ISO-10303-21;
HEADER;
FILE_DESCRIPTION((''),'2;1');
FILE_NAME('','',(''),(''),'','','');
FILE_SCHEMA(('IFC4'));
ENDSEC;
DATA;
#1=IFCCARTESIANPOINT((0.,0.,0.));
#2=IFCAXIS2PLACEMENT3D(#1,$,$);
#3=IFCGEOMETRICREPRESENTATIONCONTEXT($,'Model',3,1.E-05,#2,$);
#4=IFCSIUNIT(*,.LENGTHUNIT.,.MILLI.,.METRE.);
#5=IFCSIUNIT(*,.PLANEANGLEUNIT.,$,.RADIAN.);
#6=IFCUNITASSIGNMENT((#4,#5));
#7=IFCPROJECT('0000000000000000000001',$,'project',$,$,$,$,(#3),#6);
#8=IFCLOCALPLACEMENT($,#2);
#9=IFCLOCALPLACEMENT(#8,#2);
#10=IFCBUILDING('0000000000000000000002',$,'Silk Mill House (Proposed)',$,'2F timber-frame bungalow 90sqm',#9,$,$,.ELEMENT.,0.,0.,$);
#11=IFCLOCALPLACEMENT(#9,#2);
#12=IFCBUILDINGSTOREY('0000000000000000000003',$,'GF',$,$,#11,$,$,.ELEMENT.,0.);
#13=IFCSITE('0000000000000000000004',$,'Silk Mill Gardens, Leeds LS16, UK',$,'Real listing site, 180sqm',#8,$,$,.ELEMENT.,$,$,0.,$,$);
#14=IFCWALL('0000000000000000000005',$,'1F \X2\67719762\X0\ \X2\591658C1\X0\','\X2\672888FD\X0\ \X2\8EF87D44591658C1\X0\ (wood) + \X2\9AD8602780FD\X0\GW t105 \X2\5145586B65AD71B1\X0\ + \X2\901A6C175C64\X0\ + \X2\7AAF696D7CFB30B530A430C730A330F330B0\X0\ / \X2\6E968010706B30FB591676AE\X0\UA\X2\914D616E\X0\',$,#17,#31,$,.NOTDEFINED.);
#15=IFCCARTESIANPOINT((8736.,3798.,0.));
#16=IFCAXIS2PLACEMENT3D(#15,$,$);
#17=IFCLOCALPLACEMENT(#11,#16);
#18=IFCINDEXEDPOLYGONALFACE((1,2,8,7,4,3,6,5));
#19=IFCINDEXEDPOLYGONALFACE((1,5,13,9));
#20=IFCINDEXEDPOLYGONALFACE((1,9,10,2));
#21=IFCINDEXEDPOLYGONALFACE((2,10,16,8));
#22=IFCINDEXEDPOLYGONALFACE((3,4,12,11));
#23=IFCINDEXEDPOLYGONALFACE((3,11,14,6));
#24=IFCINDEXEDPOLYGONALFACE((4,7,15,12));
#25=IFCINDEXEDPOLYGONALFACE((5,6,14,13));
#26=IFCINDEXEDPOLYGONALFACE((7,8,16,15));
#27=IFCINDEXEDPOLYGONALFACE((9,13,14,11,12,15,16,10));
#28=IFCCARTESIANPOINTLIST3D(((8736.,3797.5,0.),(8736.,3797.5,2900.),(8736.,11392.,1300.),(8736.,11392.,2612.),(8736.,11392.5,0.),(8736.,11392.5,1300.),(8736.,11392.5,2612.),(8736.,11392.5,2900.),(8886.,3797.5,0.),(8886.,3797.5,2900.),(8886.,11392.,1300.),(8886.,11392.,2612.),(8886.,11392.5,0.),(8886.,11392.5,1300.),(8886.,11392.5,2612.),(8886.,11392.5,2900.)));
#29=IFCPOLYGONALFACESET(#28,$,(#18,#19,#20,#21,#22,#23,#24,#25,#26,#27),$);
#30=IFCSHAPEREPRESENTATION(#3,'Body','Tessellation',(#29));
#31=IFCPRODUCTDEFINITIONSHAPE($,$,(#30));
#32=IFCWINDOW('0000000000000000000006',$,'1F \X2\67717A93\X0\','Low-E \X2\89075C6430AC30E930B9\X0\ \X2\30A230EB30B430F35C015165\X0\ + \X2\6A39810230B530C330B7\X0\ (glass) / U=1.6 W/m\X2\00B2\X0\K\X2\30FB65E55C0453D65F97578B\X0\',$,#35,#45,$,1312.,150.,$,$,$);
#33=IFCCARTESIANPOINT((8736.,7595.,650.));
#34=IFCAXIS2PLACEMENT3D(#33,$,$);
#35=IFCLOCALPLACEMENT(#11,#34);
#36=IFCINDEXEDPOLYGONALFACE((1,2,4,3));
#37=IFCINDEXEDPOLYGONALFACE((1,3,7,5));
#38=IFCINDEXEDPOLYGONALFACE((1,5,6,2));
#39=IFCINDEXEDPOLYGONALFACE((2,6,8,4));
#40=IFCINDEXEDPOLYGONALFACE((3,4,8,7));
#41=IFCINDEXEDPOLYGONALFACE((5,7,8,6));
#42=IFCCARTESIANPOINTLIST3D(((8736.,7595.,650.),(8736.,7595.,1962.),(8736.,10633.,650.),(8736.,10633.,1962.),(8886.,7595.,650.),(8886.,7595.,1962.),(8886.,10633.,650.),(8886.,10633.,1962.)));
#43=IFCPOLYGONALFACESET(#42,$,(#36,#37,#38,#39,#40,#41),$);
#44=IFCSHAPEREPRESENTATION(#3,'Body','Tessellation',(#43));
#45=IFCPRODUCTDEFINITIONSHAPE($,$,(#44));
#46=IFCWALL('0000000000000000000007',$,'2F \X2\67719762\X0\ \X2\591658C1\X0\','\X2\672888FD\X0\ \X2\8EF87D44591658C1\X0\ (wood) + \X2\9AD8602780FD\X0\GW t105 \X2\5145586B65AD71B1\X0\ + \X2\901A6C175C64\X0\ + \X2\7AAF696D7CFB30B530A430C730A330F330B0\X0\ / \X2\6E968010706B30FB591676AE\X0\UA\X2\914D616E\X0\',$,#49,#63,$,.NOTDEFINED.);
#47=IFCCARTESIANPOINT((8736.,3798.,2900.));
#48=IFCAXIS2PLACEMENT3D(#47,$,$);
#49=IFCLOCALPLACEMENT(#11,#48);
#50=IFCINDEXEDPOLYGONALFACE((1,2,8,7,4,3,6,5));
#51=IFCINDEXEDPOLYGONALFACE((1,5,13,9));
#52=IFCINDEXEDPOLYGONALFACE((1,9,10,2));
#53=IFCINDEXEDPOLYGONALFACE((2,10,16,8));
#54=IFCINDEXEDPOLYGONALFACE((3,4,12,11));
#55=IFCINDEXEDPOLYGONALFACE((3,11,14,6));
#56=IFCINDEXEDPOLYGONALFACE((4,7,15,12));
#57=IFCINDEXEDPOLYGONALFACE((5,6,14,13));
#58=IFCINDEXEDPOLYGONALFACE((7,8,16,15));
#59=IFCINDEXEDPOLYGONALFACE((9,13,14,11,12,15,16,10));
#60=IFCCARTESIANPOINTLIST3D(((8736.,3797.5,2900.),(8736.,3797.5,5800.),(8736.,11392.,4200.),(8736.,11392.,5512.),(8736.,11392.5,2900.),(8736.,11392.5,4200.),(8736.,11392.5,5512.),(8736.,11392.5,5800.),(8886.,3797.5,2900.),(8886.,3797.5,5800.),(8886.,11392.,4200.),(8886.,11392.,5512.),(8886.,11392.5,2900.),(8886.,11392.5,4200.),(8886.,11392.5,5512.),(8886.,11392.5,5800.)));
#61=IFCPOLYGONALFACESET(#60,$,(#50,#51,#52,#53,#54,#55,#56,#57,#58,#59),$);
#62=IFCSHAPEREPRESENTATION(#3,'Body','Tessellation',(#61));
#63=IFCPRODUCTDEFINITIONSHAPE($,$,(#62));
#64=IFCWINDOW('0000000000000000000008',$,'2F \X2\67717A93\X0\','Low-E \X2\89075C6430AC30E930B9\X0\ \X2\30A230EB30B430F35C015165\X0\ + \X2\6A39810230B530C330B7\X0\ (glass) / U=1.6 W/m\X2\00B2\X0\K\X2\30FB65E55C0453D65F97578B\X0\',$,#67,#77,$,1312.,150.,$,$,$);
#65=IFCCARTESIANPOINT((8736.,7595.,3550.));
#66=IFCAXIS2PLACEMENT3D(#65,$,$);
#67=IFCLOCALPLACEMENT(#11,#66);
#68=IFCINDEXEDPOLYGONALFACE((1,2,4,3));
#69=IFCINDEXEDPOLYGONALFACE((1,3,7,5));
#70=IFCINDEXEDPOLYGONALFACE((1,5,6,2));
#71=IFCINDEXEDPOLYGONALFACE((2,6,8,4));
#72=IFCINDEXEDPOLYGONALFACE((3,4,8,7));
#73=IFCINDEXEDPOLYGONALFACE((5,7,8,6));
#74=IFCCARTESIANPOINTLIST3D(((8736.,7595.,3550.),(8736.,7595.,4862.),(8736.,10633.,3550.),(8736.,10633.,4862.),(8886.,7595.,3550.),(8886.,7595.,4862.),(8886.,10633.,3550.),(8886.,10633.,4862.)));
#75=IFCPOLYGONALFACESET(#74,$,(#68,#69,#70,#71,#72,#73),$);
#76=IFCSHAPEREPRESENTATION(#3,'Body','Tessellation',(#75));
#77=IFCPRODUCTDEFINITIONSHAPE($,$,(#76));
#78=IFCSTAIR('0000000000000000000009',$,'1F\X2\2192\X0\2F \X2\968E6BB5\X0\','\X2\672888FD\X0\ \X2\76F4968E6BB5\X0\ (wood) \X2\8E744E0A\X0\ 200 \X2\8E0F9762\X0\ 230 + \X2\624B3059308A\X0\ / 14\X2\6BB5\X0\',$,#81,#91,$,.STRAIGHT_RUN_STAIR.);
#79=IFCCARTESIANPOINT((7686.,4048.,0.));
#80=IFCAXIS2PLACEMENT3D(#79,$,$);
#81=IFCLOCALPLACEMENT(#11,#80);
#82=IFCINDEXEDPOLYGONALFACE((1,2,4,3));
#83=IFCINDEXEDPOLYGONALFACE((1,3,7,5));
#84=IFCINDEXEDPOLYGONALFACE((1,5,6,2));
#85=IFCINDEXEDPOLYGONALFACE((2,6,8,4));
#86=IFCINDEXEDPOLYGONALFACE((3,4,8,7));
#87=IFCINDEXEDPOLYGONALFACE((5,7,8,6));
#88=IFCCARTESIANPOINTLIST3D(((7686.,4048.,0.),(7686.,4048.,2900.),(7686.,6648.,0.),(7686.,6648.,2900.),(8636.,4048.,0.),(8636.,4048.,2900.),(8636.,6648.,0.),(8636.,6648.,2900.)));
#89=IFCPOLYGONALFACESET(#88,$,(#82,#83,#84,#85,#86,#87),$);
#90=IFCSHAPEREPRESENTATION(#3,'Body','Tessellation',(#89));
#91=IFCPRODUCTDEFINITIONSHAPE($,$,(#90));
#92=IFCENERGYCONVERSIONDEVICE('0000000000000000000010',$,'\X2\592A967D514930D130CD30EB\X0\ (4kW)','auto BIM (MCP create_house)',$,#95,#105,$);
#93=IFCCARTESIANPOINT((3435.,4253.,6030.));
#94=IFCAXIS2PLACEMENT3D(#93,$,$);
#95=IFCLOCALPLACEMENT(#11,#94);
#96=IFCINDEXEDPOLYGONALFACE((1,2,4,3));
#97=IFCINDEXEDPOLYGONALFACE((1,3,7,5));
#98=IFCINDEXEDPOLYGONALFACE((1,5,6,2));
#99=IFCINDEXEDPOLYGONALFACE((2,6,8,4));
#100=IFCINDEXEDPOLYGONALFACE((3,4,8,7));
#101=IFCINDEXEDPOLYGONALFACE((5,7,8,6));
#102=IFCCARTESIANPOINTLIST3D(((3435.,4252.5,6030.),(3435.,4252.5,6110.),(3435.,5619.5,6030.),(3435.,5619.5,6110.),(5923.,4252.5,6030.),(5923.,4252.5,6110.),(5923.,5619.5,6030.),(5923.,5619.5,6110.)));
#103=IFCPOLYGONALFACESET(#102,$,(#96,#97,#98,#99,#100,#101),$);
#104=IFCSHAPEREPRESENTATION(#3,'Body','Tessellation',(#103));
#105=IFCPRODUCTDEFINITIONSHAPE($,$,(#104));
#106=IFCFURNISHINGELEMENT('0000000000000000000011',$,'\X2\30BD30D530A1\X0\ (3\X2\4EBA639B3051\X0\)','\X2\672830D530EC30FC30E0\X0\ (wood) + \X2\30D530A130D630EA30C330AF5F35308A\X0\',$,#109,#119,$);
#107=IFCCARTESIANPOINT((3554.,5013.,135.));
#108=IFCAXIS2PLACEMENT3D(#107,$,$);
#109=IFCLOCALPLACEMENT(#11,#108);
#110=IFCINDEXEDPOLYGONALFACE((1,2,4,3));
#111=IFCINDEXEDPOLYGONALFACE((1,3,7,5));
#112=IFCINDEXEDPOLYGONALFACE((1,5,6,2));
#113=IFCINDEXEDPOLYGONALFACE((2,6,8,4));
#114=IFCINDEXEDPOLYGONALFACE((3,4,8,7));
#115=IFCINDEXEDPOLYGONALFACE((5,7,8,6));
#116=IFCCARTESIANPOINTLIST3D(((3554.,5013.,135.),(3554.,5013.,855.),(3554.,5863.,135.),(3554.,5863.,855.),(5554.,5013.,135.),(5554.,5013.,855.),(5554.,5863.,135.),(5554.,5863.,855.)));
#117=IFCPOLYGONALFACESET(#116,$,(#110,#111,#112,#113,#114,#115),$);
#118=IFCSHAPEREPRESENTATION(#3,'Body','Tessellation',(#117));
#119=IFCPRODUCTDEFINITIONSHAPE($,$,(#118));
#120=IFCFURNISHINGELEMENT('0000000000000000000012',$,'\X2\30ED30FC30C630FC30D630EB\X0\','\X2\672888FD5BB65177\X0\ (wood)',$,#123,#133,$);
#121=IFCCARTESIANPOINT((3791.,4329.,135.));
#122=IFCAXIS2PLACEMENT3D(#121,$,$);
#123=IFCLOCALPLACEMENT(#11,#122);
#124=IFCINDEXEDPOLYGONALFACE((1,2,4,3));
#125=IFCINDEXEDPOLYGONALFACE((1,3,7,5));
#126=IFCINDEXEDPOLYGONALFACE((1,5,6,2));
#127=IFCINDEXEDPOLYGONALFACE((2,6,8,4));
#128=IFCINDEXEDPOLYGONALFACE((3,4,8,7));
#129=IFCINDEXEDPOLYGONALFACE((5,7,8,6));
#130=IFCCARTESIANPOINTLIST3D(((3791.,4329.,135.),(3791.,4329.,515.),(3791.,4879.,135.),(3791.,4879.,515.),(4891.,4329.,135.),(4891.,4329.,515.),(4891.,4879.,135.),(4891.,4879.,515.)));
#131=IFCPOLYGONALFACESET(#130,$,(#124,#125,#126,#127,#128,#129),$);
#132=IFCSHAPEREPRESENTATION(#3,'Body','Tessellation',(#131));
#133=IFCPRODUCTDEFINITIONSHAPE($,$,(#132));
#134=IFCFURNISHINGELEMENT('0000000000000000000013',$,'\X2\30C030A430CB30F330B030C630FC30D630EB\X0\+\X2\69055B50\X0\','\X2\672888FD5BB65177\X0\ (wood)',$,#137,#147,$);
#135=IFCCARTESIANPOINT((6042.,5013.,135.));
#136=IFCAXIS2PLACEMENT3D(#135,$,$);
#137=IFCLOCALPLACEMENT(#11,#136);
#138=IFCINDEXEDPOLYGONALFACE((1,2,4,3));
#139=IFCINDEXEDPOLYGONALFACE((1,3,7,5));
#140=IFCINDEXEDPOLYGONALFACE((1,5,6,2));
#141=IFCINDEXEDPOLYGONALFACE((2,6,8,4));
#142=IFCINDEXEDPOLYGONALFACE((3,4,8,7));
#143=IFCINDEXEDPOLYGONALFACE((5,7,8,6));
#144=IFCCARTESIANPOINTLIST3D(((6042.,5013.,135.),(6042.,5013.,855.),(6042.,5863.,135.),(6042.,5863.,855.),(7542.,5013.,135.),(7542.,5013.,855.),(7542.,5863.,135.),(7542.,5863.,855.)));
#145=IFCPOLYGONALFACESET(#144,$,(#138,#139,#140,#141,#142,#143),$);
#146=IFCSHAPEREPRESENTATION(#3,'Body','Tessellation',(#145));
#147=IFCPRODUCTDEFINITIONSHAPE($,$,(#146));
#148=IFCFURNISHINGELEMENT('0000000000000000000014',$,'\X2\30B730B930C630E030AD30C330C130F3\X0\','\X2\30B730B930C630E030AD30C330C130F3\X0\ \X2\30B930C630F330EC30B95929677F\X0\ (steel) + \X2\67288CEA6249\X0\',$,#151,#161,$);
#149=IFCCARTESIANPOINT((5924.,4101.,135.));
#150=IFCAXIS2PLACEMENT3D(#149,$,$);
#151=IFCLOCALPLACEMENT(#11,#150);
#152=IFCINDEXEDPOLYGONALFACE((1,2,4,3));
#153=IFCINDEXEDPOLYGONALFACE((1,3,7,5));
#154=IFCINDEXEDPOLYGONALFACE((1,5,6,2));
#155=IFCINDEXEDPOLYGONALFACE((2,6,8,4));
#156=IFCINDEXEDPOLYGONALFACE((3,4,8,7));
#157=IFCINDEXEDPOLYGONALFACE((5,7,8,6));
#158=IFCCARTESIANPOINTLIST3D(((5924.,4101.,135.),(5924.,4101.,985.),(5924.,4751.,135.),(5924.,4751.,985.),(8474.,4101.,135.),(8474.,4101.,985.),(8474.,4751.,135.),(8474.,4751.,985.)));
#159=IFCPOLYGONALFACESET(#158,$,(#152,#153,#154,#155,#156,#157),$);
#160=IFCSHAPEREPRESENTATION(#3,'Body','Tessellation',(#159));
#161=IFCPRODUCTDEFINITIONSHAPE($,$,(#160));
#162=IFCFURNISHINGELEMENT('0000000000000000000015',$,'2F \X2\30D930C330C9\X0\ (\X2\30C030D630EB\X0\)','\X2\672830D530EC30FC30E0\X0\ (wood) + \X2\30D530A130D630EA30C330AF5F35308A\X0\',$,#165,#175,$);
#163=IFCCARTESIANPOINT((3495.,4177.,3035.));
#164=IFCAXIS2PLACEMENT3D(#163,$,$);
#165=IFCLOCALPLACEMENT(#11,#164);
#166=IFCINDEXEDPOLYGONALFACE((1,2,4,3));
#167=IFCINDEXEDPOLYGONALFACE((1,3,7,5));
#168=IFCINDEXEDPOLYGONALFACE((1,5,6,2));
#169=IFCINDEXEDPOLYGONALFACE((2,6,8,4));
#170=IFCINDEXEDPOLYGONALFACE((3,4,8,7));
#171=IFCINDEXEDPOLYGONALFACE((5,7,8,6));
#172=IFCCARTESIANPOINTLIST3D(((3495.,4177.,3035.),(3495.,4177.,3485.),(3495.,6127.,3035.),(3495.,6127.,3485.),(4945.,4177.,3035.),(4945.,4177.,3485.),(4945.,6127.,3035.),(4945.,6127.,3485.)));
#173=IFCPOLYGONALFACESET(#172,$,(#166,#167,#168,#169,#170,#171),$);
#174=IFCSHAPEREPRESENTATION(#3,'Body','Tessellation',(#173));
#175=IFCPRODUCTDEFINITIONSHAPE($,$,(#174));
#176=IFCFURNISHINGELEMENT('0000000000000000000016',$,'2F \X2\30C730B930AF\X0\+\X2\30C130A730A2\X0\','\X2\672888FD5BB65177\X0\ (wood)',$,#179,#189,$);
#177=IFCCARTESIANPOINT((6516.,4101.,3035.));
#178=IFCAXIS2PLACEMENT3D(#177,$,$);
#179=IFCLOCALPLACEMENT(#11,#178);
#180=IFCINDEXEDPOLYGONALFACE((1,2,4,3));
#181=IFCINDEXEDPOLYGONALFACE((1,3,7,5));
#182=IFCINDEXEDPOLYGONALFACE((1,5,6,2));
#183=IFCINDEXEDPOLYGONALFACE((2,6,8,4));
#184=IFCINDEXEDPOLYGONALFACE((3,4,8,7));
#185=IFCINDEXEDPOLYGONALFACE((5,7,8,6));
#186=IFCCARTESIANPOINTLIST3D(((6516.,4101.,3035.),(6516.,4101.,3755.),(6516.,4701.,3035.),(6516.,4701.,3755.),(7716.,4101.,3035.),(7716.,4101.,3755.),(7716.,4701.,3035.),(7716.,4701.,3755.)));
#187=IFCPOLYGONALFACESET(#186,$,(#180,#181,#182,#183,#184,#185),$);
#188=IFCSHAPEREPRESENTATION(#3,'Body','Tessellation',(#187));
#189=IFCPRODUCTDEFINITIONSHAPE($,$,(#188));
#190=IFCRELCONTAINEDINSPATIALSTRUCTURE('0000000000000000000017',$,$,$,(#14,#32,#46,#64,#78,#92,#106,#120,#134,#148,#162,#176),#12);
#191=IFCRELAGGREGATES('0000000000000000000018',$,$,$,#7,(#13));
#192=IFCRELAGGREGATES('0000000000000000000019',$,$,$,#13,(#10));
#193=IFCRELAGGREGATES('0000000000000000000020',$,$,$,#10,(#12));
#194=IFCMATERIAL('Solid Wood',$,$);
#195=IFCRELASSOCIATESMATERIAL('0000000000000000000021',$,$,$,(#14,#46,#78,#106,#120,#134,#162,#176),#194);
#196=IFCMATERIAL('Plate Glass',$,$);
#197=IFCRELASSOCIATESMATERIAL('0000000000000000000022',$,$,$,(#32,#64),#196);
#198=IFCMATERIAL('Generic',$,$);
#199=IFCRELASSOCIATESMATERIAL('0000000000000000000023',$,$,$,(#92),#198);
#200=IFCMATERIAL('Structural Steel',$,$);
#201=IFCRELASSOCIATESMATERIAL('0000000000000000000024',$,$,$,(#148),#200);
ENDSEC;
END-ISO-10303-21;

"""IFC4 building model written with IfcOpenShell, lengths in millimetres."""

from ifc_helpers import new_model, si_unit, frame, frame_2d, origin, place, context, project, spatial, rectangle, extrude, material, element, fill, save


model = new_model("IFC4")

# Units and contexts
model_context = context("Model", 3, precision=1e-05, world=origin())
ifc_project = project(units=[si_unit("LENGTHUNIT", "METRE", prefix="MILLI"), si_unit("PLANEANGLEUNIT", "RADIAN")], contexts=[model_context])

# Site, building, storey
site_placement = place(None, origin())
site = spatial("IfcSite", under=ifc_project, at=site_placement, Name="Silk Mill Gardens, Leeds LS16, UK", ObjectType="Real listing site, 180sqm", CompositionType="ELEMENT", RefElevation=0.0)
building_placement = place(site_placement, origin())
building = spatial("IfcBuilding", under=site, at=building_placement, Name="Silk Mill House (Proposed)", ObjectType="2F timber-frame bungalow 90sqm", CompositionType="ELEMENT", ElevationOfRefHeight=0.0, ElevationOfTerrain=0.0)
storey_placement = place(building_placement, origin())
storey = spatial("IfcBuildingStorey", under=building, at=storey_placement, Name="GF", CompositionType="ELEMENT", Elevation=0.0)

# Wall, opening, window
ifc_material_1 = material(Name="Solid Wood")
wall_1_placement = place(storey_placement, frame((8736.0, 3798.0, 0.0)))
wall_1 = element("IfcWall", 1, at=wall_1_placement, inside=storey, material=ifc_material_1, Name="1F 東面 外壁", Description="木製 軸組外壁 (wood) + 高性能GW t105 充填断熱 + 通気層 + 窯業系サイディング / 準耐火・外皮UA配慮", PredefinedType="NOTDEFINED", context=model_context, shape_type="SweptSolid", body=[
    extrude(rectangle(XDim=150.0, YDim=7595.0, at=frame_2d((75.0, 3797.0))), frame((8736.0, 3798.0, 0.0)), (0.0, 0.0, 1.0), 2900.0),
])
opening_1_placement = place(storey_placement, frame((8736.0, 7595.0, 650.0)))
opening_1 = element("IfcOpeningElement", 2, at=opening_1_placement, cuts=wall_1, PredefinedType="NOTDEFINED", context=model_context, shape_type="SweptSolid", body=[
    extrude(rectangle(XDim=150.0, YDim=3038.0, at=frame_2d((75.0, 1519.0))), frame((8736.0, 7595.0, 650.0)), (0.0, 0.0, 1.0), 1312.0),
])
ifc_material_2 = material(Name="Plate Glass")
window_1_placement = place(storey_placement, frame((8736.0, 7595.0, 650.0)))
window_1 = element("IfcWindow", 3, at=window_1_placement, inside=storey, material=ifc_material_2, Name="1F 東窓", Description="Low-E 複層ガラス アルゴン封入 + 樹脂サッシ (glass) / U=1.6 W/m²K・日射取得型", OverallHeight=1312.0, OverallWidth=150.0, context=model_context, shape_type="SweptSolid", body=[
    extrude(rectangle(XDim=150.0, YDim=3038.0, at=frame_2d((75.0, 1519.0))), frame((8736.0, 7595.0, 650.0)), (0.0, 0.0, 1.0), 1312.0),
])
fill(opening_1, window_1)

# Wall, opening, window
wall_2_placement = place(storey_placement, frame((8736.0, 3798.0, 2900.0)))
wall_2 = element("IfcWall", 4, at=wall_2_placement, inside=storey, material=ifc_material_1, Name="2F 東面 外壁", Description="木製 軸組外壁 (wood) + 高性能GW t105 充填断熱 + 通気層 + 窯業系サイディング / 準耐火・外皮UA配慮", PredefinedType="NOTDEFINED", context=model_context, shape_type="SweptSolid", body=[
    extrude(rectangle(XDim=150.0, YDim=7595.0, at=frame_2d((75.0, 3797.0))), frame((8736.0, 3798.0, 2900.0)), (0.0, 0.0, 1.0), 2900.0),
])
opening_2_placement = place(storey_placement, frame((8736.0, 7595.0, 3550.0)))
opening_2 = element("IfcOpeningElement", 5, at=opening_2_placement, cuts=wall_2, PredefinedType="NOTDEFINED", context=model_context, shape_type="SweptSolid", body=[
    extrude(rectangle(XDim=150.0, YDim=3038.0, at=frame_2d((75.0, 1519.0))), frame((8736.0, 7595.0, 3550.0)), (0.0, 0.0, 1.0), 1312.0),
])
window_2_placement = place(storey_placement, frame((8736.0, 7595.0, 3550.0)))
window_2 = element("IfcWindow", 6, at=window_2_placement, inside=storey, material=ifc_material_2, Name="2F 東窓", Description="Low-E 複層ガラス アルゴン封入 + 樹脂サッシ (glass) / U=1.6 W/m²K・日射取得型", OverallHeight=1312.0, OverallWidth=150.0, context=model_context, shape_type="SweptSolid", body=[
    extrude(rectangle(XDim=150.0, YDim=3038.0, at=frame_2d((75.0, 1519.0))), frame((8736.0, 7595.0, 3550.0)), (0.0, 0.0, 1.0), 1312.0),
])
fill(opening_2, window_2)

# Stair
stair_placement = place(storey_placement, frame((7686.0, 4048.0, 0.0)))
element("IfcStair", 7, at=stair_placement, inside=storey, material=ifc_material_1, Name="1F→2F 階段", Description="木製 直階段 (wood) 蹴上 200 踏面 230 + 手すり / 14段", PredefinedType="STRAIGHT_RUN_STAIR", context=model_context, shape_type="SweptSolid", body=[
    extrude(rectangle(XDim=950.0, YDim=2600.0, at=frame_2d((475.0, 1300.0))), frame((7686.0, 4048.0, 0.0)), (0.0, 0.0, 1.0), 2900.0),
])

# Energy conversion device
ifc_material_3 = material(Name="Generic")
energy_conversion_device_placement = place(storey_placement, frame((3435.0, 4253.0, 6030.0)))
element("IfcEnergyConversionDevice", 8, at=energy_conversion_device_placement, inside=storey, material=ifc_material_3, Name="太陽光パネル (4kW)", Description="auto BIM (MCP create_house)", context=model_context, shape_type="SweptSolid", body=[
    extrude(rectangle(XDim=2488.0, YDim=1367.0, at=frame_2d((1244.0, 683.0))), frame((3435.0, 4253.0, 6030.0)), (0.0, 0.0, 1.0), 80.0),
])

# Furnishing elements
furnishing_1_placement = place(storey_placement, frame((3554.0, 5013.0, 135.0)))
element("IfcFurnishingElement", 9, at=furnishing_1_placement, inside=storey, material=ifc_material_1, Name="ソファ (3人掛け)", Description="木フレーム (wood) + ファブリック張り", context=model_context, shape_type="SweptSolid", body=[
    extrude(rectangle(XDim=2000.0, YDim=850.0, at=frame_2d((1000.0, 425.0))), frame((3554.0, 5013.0, 135.0)), (0.0, 0.0, 1.0), 720.0),
])
furnishing_2_placement = place(storey_placement, frame((3791.0, 4329.0, 135.0)))
element("IfcFurnishingElement", 10, at=furnishing_2_placement, inside=storey, material=ifc_material_1, Name="ローテーブル", Description="木製家具 (wood)", context=model_context, shape_type="SweptSolid", body=[
    extrude(rectangle(XDim=1100.0, YDim=550.0, at=frame_2d((550.0, 275.0))), frame((3791.0, 4329.0, 135.0)), (0.0, 0.0, 1.0), 380.0),
])
furnishing_3_placement = place(storey_placement, frame((6042.0, 5013.0, 135.0)))
element("IfcFurnishingElement", 11, at=furnishing_3_placement, inside=storey, material=ifc_material_1, Name="ダイニングテーブル+椅子", Description="木製家具 (wood)", context=model_context, shape_type="SweptSolid", body=[
    extrude(rectangle(XDim=1500.0, YDim=850.0, at=frame_2d((750.0, 425.0))), frame((6042.0, 5013.0, 135.0)), (0.0, 0.0, 1.0), 720.0),
])
ifc_material_4 = material(Name="Structural Steel")
furnishing_4_placement = place(storey_placement, frame((5924.0, 4101.0, 135.0)))
element("IfcFurnishingElement", 12, at=furnishing_4_placement, inside=storey, material=ifc_material_4, Name="システムキッチン", Description="システムキッチン ステンレス天板 (steel) + 木質扉", context=model_context, shape_type="SweptSolid", body=[
    extrude(rectangle(XDim=2550.0, YDim=650.0, at=frame_2d((1275.0, 325.0))), frame((5924.0, 4101.0, 135.0)), (0.0, 0.0, 1.0), 850.0),
])
furnishing_5_placement = place(storey_placement, frame((3495.0, 4177.0, 3035.0)))
element("IfcFurnishingElement", 13, at=furnishing_5_placement, inside=storey, material=ifc_material_1, Name="2F ベッド (ダブル)", Description="木フレーム (wood) + ファブリック張り", context=model_context, shape_type="SweptSolid", body=[
    extrude(rectangle(XDim=1450.0, YDim=1950.0, at=frame_2d((725.0, 975.0))), frame((3495.0, 4177.0, 3035.0)), (0.0, 0.0, 1.0), 450.0),
])
furnishing_6_placement = place(storey_placement, frame((6516.0, 4101.0, 3035.0)))
element("IfcFurnishingElement", 14, at=furnishing_6_placement, inside=storey, material=ifc_material_1, Name="2F デスク+チェア", Description="木製家具 (wood)", context=model_context, shape_type="SweptSolid", body=[
    extrude(rectangle(XDim=1200.0, YDim=600.0, at=frame_2d((600.0, 300.0))), frame((6516.0, 4101.0, 3035.0)), (0.0, 0.0, 1.0), 720.0),
])

save(model, "model.ifc")
